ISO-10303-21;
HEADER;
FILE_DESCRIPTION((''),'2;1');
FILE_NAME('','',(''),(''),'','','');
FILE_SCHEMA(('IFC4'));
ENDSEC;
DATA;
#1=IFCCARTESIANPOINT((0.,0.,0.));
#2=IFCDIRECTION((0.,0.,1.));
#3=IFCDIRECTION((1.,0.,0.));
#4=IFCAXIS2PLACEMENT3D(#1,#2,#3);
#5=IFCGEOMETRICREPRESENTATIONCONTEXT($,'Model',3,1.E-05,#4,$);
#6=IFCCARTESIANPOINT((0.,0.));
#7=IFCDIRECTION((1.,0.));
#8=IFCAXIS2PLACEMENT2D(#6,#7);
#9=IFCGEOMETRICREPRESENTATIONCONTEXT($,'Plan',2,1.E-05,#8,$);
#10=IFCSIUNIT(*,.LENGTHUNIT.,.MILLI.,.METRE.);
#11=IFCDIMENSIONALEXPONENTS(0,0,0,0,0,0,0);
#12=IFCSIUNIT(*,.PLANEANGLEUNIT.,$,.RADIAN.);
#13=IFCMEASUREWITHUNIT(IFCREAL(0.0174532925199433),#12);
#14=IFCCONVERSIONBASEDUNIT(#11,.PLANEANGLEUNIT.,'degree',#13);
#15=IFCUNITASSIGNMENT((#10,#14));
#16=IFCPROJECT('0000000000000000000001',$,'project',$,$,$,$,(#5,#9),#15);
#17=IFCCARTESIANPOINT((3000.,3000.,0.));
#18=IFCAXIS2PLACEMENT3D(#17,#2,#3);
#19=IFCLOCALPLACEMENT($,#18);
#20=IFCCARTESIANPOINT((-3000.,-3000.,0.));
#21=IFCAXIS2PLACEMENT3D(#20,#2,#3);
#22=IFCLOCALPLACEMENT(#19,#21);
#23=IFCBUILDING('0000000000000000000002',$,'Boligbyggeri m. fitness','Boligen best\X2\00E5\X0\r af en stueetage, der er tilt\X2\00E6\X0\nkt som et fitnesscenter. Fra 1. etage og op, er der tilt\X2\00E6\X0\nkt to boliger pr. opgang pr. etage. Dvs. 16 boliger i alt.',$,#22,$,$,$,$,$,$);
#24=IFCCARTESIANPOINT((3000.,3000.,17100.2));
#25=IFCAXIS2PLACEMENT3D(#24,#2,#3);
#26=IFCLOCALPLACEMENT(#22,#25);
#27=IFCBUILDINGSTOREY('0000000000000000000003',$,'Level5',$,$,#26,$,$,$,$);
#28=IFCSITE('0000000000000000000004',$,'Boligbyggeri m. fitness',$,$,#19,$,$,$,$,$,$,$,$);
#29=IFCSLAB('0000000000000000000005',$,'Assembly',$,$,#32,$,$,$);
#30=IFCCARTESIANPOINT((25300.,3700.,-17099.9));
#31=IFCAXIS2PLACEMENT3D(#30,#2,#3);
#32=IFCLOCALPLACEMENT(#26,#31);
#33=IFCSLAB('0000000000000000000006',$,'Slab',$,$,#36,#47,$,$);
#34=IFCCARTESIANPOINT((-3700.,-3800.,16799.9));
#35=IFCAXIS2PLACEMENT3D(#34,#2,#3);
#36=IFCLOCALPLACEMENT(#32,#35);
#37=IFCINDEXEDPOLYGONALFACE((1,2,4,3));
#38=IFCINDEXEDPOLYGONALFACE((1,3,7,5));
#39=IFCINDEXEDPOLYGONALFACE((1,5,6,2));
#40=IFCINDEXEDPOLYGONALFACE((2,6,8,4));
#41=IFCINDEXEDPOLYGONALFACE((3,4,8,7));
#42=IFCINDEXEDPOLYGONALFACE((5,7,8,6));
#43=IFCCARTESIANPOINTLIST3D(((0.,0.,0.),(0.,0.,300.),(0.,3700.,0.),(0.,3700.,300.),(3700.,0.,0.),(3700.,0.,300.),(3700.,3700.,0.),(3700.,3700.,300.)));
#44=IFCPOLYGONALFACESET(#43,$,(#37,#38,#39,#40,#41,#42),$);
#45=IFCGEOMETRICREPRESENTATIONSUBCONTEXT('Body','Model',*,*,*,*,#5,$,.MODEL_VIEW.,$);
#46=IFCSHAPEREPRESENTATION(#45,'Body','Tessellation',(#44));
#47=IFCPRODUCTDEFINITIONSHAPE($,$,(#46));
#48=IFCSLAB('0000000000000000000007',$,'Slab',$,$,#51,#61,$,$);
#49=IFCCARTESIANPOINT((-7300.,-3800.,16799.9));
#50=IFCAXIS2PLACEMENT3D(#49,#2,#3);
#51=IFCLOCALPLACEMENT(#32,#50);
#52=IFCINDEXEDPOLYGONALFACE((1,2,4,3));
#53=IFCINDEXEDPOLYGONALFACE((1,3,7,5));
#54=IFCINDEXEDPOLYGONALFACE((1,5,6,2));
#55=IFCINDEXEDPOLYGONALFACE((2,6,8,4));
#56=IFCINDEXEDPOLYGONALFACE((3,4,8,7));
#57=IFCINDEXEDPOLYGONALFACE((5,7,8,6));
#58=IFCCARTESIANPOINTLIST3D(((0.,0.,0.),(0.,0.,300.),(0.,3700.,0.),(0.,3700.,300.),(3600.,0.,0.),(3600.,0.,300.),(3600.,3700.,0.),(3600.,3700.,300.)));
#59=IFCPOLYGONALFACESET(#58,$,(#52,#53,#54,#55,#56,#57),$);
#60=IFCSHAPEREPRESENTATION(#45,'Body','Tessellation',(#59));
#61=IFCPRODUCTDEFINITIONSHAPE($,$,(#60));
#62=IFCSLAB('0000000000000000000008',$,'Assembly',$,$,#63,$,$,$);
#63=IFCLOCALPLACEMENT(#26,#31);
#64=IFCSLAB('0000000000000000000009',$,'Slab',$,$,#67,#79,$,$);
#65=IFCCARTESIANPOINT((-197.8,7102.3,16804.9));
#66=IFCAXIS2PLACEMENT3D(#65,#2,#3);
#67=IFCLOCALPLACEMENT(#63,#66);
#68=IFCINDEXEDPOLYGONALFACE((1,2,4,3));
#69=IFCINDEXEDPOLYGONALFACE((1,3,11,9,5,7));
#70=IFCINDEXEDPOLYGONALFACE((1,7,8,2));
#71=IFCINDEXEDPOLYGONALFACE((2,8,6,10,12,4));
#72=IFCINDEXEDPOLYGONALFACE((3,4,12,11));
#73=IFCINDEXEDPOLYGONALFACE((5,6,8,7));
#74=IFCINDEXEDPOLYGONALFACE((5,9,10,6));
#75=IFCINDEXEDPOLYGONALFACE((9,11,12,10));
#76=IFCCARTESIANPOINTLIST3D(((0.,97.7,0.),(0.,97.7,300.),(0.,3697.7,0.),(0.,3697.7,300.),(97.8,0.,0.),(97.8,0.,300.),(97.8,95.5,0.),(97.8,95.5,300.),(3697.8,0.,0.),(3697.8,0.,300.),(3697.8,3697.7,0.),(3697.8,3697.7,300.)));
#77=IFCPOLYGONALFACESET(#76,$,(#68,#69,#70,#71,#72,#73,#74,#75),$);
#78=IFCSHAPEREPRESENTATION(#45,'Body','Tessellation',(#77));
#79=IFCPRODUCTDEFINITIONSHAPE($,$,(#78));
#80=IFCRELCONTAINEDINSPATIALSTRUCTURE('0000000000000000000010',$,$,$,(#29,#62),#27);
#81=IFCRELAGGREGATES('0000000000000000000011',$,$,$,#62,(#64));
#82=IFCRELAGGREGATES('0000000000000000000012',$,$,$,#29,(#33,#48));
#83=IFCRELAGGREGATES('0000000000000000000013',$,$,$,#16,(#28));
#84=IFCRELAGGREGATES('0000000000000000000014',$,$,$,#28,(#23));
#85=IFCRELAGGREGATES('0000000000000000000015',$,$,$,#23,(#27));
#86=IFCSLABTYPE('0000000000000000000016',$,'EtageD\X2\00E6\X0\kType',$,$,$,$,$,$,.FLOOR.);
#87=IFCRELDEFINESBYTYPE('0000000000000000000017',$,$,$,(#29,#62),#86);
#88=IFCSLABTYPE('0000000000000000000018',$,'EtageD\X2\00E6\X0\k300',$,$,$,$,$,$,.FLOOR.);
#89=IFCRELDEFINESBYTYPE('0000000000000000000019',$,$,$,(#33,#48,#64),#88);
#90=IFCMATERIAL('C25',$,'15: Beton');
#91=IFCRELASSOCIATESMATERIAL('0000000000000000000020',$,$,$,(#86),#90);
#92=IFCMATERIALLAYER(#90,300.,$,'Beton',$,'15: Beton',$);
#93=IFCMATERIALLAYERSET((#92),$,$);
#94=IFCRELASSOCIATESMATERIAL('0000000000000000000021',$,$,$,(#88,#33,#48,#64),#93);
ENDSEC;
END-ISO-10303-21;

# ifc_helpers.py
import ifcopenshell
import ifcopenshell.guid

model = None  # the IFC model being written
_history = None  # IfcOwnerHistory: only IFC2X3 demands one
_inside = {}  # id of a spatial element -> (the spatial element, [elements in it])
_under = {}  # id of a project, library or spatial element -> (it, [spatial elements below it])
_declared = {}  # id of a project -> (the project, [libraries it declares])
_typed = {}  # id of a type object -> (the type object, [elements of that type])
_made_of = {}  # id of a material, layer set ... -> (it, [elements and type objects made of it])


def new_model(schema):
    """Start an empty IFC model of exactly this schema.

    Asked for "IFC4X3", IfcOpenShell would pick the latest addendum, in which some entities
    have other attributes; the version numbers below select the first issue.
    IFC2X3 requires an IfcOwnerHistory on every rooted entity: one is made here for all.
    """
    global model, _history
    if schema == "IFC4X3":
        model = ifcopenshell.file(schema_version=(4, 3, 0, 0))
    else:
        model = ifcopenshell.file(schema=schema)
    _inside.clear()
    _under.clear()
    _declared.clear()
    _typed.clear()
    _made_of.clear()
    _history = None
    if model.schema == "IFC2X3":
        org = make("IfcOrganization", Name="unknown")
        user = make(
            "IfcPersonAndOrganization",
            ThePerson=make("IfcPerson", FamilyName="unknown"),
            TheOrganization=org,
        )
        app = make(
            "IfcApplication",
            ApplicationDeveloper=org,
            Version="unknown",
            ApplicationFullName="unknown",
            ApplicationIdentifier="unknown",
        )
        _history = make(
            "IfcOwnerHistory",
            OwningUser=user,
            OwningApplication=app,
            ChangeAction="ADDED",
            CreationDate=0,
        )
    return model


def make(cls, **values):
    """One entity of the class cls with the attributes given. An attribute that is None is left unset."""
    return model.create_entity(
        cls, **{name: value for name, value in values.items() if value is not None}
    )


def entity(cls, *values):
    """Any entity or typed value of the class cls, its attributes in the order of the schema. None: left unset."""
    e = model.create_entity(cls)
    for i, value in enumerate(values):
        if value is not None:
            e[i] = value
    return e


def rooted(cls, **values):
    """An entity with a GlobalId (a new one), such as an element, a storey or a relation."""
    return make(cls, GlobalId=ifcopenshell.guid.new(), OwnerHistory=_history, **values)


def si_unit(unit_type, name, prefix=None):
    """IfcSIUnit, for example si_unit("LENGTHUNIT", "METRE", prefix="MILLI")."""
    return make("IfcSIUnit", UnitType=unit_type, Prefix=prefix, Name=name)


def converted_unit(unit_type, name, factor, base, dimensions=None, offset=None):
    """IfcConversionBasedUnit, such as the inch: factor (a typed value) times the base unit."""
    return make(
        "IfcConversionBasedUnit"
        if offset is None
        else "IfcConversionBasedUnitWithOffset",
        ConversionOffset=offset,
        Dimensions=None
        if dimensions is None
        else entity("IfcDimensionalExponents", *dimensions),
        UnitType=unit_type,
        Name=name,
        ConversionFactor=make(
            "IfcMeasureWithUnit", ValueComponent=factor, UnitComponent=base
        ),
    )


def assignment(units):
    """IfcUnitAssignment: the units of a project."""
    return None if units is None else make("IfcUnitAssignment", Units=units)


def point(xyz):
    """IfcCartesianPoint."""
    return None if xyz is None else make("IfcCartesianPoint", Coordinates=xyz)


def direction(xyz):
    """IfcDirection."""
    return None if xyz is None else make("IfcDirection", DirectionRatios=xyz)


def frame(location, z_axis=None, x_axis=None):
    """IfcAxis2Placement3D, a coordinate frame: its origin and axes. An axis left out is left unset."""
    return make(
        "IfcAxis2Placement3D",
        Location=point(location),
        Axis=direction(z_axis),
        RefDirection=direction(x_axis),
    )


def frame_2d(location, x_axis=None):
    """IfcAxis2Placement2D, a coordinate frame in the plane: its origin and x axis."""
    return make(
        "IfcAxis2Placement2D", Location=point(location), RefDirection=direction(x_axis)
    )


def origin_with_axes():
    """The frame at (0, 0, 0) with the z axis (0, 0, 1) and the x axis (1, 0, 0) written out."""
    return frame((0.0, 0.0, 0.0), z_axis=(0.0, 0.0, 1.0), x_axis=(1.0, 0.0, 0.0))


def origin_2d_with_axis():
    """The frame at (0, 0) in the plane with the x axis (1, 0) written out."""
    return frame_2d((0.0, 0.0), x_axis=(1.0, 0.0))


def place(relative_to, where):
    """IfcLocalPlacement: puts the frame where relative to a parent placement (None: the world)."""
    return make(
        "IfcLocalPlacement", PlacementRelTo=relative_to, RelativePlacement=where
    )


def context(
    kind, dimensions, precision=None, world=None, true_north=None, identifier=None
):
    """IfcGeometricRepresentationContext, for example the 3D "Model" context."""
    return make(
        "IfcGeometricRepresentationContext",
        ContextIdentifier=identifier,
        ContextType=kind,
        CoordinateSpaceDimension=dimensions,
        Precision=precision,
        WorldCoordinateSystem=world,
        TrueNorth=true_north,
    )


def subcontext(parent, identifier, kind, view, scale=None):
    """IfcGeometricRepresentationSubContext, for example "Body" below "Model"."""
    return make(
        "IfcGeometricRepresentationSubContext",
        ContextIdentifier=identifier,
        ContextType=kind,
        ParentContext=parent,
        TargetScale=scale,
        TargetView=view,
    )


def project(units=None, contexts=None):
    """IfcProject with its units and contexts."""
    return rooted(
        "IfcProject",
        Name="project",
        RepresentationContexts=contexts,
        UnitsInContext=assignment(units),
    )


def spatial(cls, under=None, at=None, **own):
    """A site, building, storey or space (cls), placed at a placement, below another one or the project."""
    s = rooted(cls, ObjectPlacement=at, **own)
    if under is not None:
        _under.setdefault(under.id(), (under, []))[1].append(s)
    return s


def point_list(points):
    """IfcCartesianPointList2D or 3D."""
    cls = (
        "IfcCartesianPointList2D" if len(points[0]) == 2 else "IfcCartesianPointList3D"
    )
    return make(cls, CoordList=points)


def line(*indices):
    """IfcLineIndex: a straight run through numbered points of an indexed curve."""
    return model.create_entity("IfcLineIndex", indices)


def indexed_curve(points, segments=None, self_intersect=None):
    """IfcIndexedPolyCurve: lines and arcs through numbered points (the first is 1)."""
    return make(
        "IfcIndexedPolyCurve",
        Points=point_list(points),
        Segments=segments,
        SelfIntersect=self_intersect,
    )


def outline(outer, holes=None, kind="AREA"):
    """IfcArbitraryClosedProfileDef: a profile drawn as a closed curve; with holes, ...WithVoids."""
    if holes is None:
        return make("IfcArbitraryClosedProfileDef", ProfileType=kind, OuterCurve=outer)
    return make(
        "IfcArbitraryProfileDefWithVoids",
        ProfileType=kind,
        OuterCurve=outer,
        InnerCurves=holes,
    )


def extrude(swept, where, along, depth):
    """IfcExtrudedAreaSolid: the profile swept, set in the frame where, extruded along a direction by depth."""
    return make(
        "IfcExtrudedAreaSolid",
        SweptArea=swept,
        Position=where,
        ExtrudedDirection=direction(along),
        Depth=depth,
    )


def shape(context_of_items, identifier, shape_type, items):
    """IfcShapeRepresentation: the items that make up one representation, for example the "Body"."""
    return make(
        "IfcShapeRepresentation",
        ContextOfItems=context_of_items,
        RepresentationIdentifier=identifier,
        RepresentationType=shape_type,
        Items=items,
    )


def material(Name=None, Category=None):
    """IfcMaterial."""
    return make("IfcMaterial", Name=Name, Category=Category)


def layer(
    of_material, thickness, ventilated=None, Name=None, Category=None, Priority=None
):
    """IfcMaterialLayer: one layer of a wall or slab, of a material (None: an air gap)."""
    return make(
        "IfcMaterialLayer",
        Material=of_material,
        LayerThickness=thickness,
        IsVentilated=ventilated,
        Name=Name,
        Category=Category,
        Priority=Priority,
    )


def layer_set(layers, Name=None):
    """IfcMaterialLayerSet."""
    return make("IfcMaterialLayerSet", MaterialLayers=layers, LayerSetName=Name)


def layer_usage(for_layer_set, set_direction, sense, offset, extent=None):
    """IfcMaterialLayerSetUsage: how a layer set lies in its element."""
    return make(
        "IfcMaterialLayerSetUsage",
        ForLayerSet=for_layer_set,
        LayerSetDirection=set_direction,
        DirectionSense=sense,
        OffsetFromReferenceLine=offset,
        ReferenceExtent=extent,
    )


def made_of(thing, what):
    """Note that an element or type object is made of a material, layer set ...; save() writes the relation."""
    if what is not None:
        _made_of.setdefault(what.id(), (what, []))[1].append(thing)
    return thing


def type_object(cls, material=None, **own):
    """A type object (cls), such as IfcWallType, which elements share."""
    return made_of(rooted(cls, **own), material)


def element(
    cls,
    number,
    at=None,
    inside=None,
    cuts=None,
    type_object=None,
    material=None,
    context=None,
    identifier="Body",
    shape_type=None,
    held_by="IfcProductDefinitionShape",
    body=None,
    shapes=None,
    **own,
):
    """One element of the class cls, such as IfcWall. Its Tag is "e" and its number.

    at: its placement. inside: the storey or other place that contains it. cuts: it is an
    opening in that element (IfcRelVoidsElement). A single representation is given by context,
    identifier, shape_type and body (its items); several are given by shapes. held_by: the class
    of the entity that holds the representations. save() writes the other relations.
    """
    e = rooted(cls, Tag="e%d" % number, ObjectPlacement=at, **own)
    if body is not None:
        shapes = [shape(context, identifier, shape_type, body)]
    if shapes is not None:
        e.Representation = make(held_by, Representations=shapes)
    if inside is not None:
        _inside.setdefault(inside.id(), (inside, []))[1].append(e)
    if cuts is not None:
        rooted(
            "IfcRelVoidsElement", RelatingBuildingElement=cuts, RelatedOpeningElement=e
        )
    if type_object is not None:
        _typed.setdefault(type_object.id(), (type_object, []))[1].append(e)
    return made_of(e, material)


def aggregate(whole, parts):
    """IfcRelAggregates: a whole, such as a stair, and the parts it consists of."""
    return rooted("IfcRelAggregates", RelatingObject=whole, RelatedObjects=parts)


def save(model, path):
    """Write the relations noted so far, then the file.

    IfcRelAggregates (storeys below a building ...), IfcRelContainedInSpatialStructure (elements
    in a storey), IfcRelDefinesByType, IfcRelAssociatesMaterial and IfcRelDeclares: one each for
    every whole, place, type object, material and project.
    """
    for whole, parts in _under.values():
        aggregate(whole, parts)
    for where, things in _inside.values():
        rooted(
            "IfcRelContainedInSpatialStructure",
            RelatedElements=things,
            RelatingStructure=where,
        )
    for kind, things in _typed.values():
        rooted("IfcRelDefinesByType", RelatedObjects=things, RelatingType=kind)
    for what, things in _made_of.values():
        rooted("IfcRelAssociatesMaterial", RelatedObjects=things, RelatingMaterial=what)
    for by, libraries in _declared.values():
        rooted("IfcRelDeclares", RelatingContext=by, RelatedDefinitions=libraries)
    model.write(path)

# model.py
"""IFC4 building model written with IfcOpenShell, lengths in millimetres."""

from ifc_helpers import new_model, entity, si_unit, converted_unit, frame, origin_with_axes, origin_2d_with_axis, place, context, subcontext, project, spatial, line, indexed_curve, outline, extrude, material, layer, layer_set, layer_usage, type_object, element, aggregate, save


model = new_model("IFC4")

# Units and contexts
model_context = context("Model", 3, precision=1e-05, world=origin_with_axes())
plan_context = context("Plan", 2, precision=1e-05, world=origin_2d_with_axis())
body_context = subcontext(model_context, "Body", "Model", "MODEL_VIEW")
ifc_project = project(units=[si_unit("LENGTHUNIT", "METRE", prefix="MILLI"), converted_unit("PLANEANGLEUNIT", "degree", entity("IfcReal", 0.0174532925199433), si_unit("PLANEANGLEUNIT", "RADIAN"), dimensions=[0, 0, 0, 0, 0, 0, 0])], contexts=[model_context, plan_context])

# Site, building, storey
site_placement = place(None, frame((3000.0, 3000.0, 0.0), z_axis=(0.0, 0.0, 1.0), x_axis=(1.0, 0.0, 0.0)))
site = spatial("IfcSite", under=ifc_project, at=site_placement, Name="Boligbyggeri m. fitness")
building_placement = place(site_placement, frame((-3000.0, -3000.0, 0.0), z_axis=(0.0, 0.0, 1.0), x_axis=(1.0, 0.0, 0.0)))
building = spatial("IfcBuilding", under=site, at=building_placement, Name="Boligbyggeri m. fitness", Description="Boligen består af en stueetage, der er tiltænkt som et fitnesscenter. Fra 1. etage og op, er der tiltænkt to boliger pr. opgang pr. etage. Dvs. 16 boliger i alt.")
storey_placement = place(building_placement, frame((3000.0, 3000.0, 17100.2), z_axis=(0.0, 0.0, 1.0), x_axis=(1.0, 0.0, 0.0)))
storey = spatial("IfcBuildingStorey", under=building, at=storey_placement, Name="Level5")

# Shared definitions
ifc_material_1 = material(Name="C25", Category="15: Beton")

# Slabs
slab_type_1 = type_object("IfcSlabType", Name="EtageDækType", PredefinedType="FLOOR", material=ifc_material_1)
slab_1_placement = place(storey_placement, frame((25300.0, 3700.0, -17099.9), z_axis=(0.0, 0.0, 1.0), x_axis=(1.0, 0.0, 0.0)))
slab_1 = element("IfcSlab", 1, at=slab_1_placement, inside=storey, type_object=slab_type_1, Name="Assembly")
ifc_layer = layer(ifc_material_1, 300.0, Name="Beton", Category="15: Beton")
ifc_layer_set = layer_set([ifc_layer])
ifc_layer_usage_1 = layer_usage(ifc_layer_set, "AXIS3", "POSITIVE", 0.0)
slab_type_2 = type_object("IfcSlabType", Name="EtageDæk300", PredefinedType="FLOOR", material=ifc_layer_set)
slab_2_placement = place(slab_1_placement, frame((-3700.0, -3800.0, 16799.9), z_axis=(0.0, 0.0, 1.0), x_axis=(1.0, 0.0, 0.0)))
slab_2 = element("IfcSlab", 2, at=slab_2_placement, type_object=slab_type_2, material=ifc_layer_usage_1, Name="Slab", context=body_context, shape_type="SweptSolid", body=[
    extrude(outline(indexed_curve([(0.0, 0.0), (3700.0, 0.0), (3700.0, 3700.0), (0.0, 3700.0)], segments=[line(3, 2), line(2, 1), line(1, 4), line(4, 3)], self_intersect=False)), None, (0.0, 0.0, 1.0), 300.0),
])
ifc_layer_usage_2 = layer_usage(ifc_layer_set, "AXIS3", "POSITIVE", 0.0)
slab_3_placement = place(slab_1_placement, frame((-7300.0, -3800.0, 16799.9), z_axis=(0.0, 0.0, 1.0), x_axis=(1.0, 0.0, 0.0)))
slab_3 = element("IfcSlab", 3, at=slab_3_placement, type_object=slab_type_2, material=ifc_layer_usage_2, Name="Slab", context=body_context, shape_type="SweptSolid", body=[
    extrude(outline(indexed_curve([(0.0, 0.0), (3600.0, 0.0), (3600.0, 3700.0), (0.0, 3700.0)], segments=[line(3, 2), line(2, 1), line(1, 4), line(4, 3)], self_intersect=False)), None, (0.0, 0.0, 1.0), 300.0),
])
slab_4_placement = place(storey_placement, frame((25300.0, 3700.0, -17099.9), z_axis=(0.0, 0.0, 1.0), x_axis=(1.0, 0.0, 0.0)))
slab_4 = element("IfcSlab", 4, at=slab_4_placement, inside=storey, type_object=slab_type_1, Name="Assembly")
ifc_layer_usage_3 = layer_usage(ifc_layer_set, "AXIS3", "POSITIVE", 0.0)
slab_5_placement = place(slab_4_placement, frame((-197.8, 7102.3, 16804.9), z_axis=(0.0, 0.0, 1.0), x_axis=(1.0, 0.0, 0.0)))
slab_5 = element("IfcSlab", 5, at=slab_5_placement, type_object=slab_type_2, material=ifc_layer_usage_3, Name="Slab", context=body_context, shape_type="SweptSolid", body=[
    extrude(outline(indexed_curve([(3697.8, 3697.7), (3697.8, 0.0), (97.8, 95.5), (0.0, 3697.7), (0.0, 97.7), (97.8, 0.0)], segments=[line(6, 3), line(3, 5), line(5, 4), line(4, 1), line(1, 2), line(2, 6)], self_intersect=False)), None, (0.0, 0.0, 1.0), 300.0),
])
aggregate(slab_4, [slab_5])

aggregate(slab_1, [slab_2, slab_3])

save(model, "model.ifc")
